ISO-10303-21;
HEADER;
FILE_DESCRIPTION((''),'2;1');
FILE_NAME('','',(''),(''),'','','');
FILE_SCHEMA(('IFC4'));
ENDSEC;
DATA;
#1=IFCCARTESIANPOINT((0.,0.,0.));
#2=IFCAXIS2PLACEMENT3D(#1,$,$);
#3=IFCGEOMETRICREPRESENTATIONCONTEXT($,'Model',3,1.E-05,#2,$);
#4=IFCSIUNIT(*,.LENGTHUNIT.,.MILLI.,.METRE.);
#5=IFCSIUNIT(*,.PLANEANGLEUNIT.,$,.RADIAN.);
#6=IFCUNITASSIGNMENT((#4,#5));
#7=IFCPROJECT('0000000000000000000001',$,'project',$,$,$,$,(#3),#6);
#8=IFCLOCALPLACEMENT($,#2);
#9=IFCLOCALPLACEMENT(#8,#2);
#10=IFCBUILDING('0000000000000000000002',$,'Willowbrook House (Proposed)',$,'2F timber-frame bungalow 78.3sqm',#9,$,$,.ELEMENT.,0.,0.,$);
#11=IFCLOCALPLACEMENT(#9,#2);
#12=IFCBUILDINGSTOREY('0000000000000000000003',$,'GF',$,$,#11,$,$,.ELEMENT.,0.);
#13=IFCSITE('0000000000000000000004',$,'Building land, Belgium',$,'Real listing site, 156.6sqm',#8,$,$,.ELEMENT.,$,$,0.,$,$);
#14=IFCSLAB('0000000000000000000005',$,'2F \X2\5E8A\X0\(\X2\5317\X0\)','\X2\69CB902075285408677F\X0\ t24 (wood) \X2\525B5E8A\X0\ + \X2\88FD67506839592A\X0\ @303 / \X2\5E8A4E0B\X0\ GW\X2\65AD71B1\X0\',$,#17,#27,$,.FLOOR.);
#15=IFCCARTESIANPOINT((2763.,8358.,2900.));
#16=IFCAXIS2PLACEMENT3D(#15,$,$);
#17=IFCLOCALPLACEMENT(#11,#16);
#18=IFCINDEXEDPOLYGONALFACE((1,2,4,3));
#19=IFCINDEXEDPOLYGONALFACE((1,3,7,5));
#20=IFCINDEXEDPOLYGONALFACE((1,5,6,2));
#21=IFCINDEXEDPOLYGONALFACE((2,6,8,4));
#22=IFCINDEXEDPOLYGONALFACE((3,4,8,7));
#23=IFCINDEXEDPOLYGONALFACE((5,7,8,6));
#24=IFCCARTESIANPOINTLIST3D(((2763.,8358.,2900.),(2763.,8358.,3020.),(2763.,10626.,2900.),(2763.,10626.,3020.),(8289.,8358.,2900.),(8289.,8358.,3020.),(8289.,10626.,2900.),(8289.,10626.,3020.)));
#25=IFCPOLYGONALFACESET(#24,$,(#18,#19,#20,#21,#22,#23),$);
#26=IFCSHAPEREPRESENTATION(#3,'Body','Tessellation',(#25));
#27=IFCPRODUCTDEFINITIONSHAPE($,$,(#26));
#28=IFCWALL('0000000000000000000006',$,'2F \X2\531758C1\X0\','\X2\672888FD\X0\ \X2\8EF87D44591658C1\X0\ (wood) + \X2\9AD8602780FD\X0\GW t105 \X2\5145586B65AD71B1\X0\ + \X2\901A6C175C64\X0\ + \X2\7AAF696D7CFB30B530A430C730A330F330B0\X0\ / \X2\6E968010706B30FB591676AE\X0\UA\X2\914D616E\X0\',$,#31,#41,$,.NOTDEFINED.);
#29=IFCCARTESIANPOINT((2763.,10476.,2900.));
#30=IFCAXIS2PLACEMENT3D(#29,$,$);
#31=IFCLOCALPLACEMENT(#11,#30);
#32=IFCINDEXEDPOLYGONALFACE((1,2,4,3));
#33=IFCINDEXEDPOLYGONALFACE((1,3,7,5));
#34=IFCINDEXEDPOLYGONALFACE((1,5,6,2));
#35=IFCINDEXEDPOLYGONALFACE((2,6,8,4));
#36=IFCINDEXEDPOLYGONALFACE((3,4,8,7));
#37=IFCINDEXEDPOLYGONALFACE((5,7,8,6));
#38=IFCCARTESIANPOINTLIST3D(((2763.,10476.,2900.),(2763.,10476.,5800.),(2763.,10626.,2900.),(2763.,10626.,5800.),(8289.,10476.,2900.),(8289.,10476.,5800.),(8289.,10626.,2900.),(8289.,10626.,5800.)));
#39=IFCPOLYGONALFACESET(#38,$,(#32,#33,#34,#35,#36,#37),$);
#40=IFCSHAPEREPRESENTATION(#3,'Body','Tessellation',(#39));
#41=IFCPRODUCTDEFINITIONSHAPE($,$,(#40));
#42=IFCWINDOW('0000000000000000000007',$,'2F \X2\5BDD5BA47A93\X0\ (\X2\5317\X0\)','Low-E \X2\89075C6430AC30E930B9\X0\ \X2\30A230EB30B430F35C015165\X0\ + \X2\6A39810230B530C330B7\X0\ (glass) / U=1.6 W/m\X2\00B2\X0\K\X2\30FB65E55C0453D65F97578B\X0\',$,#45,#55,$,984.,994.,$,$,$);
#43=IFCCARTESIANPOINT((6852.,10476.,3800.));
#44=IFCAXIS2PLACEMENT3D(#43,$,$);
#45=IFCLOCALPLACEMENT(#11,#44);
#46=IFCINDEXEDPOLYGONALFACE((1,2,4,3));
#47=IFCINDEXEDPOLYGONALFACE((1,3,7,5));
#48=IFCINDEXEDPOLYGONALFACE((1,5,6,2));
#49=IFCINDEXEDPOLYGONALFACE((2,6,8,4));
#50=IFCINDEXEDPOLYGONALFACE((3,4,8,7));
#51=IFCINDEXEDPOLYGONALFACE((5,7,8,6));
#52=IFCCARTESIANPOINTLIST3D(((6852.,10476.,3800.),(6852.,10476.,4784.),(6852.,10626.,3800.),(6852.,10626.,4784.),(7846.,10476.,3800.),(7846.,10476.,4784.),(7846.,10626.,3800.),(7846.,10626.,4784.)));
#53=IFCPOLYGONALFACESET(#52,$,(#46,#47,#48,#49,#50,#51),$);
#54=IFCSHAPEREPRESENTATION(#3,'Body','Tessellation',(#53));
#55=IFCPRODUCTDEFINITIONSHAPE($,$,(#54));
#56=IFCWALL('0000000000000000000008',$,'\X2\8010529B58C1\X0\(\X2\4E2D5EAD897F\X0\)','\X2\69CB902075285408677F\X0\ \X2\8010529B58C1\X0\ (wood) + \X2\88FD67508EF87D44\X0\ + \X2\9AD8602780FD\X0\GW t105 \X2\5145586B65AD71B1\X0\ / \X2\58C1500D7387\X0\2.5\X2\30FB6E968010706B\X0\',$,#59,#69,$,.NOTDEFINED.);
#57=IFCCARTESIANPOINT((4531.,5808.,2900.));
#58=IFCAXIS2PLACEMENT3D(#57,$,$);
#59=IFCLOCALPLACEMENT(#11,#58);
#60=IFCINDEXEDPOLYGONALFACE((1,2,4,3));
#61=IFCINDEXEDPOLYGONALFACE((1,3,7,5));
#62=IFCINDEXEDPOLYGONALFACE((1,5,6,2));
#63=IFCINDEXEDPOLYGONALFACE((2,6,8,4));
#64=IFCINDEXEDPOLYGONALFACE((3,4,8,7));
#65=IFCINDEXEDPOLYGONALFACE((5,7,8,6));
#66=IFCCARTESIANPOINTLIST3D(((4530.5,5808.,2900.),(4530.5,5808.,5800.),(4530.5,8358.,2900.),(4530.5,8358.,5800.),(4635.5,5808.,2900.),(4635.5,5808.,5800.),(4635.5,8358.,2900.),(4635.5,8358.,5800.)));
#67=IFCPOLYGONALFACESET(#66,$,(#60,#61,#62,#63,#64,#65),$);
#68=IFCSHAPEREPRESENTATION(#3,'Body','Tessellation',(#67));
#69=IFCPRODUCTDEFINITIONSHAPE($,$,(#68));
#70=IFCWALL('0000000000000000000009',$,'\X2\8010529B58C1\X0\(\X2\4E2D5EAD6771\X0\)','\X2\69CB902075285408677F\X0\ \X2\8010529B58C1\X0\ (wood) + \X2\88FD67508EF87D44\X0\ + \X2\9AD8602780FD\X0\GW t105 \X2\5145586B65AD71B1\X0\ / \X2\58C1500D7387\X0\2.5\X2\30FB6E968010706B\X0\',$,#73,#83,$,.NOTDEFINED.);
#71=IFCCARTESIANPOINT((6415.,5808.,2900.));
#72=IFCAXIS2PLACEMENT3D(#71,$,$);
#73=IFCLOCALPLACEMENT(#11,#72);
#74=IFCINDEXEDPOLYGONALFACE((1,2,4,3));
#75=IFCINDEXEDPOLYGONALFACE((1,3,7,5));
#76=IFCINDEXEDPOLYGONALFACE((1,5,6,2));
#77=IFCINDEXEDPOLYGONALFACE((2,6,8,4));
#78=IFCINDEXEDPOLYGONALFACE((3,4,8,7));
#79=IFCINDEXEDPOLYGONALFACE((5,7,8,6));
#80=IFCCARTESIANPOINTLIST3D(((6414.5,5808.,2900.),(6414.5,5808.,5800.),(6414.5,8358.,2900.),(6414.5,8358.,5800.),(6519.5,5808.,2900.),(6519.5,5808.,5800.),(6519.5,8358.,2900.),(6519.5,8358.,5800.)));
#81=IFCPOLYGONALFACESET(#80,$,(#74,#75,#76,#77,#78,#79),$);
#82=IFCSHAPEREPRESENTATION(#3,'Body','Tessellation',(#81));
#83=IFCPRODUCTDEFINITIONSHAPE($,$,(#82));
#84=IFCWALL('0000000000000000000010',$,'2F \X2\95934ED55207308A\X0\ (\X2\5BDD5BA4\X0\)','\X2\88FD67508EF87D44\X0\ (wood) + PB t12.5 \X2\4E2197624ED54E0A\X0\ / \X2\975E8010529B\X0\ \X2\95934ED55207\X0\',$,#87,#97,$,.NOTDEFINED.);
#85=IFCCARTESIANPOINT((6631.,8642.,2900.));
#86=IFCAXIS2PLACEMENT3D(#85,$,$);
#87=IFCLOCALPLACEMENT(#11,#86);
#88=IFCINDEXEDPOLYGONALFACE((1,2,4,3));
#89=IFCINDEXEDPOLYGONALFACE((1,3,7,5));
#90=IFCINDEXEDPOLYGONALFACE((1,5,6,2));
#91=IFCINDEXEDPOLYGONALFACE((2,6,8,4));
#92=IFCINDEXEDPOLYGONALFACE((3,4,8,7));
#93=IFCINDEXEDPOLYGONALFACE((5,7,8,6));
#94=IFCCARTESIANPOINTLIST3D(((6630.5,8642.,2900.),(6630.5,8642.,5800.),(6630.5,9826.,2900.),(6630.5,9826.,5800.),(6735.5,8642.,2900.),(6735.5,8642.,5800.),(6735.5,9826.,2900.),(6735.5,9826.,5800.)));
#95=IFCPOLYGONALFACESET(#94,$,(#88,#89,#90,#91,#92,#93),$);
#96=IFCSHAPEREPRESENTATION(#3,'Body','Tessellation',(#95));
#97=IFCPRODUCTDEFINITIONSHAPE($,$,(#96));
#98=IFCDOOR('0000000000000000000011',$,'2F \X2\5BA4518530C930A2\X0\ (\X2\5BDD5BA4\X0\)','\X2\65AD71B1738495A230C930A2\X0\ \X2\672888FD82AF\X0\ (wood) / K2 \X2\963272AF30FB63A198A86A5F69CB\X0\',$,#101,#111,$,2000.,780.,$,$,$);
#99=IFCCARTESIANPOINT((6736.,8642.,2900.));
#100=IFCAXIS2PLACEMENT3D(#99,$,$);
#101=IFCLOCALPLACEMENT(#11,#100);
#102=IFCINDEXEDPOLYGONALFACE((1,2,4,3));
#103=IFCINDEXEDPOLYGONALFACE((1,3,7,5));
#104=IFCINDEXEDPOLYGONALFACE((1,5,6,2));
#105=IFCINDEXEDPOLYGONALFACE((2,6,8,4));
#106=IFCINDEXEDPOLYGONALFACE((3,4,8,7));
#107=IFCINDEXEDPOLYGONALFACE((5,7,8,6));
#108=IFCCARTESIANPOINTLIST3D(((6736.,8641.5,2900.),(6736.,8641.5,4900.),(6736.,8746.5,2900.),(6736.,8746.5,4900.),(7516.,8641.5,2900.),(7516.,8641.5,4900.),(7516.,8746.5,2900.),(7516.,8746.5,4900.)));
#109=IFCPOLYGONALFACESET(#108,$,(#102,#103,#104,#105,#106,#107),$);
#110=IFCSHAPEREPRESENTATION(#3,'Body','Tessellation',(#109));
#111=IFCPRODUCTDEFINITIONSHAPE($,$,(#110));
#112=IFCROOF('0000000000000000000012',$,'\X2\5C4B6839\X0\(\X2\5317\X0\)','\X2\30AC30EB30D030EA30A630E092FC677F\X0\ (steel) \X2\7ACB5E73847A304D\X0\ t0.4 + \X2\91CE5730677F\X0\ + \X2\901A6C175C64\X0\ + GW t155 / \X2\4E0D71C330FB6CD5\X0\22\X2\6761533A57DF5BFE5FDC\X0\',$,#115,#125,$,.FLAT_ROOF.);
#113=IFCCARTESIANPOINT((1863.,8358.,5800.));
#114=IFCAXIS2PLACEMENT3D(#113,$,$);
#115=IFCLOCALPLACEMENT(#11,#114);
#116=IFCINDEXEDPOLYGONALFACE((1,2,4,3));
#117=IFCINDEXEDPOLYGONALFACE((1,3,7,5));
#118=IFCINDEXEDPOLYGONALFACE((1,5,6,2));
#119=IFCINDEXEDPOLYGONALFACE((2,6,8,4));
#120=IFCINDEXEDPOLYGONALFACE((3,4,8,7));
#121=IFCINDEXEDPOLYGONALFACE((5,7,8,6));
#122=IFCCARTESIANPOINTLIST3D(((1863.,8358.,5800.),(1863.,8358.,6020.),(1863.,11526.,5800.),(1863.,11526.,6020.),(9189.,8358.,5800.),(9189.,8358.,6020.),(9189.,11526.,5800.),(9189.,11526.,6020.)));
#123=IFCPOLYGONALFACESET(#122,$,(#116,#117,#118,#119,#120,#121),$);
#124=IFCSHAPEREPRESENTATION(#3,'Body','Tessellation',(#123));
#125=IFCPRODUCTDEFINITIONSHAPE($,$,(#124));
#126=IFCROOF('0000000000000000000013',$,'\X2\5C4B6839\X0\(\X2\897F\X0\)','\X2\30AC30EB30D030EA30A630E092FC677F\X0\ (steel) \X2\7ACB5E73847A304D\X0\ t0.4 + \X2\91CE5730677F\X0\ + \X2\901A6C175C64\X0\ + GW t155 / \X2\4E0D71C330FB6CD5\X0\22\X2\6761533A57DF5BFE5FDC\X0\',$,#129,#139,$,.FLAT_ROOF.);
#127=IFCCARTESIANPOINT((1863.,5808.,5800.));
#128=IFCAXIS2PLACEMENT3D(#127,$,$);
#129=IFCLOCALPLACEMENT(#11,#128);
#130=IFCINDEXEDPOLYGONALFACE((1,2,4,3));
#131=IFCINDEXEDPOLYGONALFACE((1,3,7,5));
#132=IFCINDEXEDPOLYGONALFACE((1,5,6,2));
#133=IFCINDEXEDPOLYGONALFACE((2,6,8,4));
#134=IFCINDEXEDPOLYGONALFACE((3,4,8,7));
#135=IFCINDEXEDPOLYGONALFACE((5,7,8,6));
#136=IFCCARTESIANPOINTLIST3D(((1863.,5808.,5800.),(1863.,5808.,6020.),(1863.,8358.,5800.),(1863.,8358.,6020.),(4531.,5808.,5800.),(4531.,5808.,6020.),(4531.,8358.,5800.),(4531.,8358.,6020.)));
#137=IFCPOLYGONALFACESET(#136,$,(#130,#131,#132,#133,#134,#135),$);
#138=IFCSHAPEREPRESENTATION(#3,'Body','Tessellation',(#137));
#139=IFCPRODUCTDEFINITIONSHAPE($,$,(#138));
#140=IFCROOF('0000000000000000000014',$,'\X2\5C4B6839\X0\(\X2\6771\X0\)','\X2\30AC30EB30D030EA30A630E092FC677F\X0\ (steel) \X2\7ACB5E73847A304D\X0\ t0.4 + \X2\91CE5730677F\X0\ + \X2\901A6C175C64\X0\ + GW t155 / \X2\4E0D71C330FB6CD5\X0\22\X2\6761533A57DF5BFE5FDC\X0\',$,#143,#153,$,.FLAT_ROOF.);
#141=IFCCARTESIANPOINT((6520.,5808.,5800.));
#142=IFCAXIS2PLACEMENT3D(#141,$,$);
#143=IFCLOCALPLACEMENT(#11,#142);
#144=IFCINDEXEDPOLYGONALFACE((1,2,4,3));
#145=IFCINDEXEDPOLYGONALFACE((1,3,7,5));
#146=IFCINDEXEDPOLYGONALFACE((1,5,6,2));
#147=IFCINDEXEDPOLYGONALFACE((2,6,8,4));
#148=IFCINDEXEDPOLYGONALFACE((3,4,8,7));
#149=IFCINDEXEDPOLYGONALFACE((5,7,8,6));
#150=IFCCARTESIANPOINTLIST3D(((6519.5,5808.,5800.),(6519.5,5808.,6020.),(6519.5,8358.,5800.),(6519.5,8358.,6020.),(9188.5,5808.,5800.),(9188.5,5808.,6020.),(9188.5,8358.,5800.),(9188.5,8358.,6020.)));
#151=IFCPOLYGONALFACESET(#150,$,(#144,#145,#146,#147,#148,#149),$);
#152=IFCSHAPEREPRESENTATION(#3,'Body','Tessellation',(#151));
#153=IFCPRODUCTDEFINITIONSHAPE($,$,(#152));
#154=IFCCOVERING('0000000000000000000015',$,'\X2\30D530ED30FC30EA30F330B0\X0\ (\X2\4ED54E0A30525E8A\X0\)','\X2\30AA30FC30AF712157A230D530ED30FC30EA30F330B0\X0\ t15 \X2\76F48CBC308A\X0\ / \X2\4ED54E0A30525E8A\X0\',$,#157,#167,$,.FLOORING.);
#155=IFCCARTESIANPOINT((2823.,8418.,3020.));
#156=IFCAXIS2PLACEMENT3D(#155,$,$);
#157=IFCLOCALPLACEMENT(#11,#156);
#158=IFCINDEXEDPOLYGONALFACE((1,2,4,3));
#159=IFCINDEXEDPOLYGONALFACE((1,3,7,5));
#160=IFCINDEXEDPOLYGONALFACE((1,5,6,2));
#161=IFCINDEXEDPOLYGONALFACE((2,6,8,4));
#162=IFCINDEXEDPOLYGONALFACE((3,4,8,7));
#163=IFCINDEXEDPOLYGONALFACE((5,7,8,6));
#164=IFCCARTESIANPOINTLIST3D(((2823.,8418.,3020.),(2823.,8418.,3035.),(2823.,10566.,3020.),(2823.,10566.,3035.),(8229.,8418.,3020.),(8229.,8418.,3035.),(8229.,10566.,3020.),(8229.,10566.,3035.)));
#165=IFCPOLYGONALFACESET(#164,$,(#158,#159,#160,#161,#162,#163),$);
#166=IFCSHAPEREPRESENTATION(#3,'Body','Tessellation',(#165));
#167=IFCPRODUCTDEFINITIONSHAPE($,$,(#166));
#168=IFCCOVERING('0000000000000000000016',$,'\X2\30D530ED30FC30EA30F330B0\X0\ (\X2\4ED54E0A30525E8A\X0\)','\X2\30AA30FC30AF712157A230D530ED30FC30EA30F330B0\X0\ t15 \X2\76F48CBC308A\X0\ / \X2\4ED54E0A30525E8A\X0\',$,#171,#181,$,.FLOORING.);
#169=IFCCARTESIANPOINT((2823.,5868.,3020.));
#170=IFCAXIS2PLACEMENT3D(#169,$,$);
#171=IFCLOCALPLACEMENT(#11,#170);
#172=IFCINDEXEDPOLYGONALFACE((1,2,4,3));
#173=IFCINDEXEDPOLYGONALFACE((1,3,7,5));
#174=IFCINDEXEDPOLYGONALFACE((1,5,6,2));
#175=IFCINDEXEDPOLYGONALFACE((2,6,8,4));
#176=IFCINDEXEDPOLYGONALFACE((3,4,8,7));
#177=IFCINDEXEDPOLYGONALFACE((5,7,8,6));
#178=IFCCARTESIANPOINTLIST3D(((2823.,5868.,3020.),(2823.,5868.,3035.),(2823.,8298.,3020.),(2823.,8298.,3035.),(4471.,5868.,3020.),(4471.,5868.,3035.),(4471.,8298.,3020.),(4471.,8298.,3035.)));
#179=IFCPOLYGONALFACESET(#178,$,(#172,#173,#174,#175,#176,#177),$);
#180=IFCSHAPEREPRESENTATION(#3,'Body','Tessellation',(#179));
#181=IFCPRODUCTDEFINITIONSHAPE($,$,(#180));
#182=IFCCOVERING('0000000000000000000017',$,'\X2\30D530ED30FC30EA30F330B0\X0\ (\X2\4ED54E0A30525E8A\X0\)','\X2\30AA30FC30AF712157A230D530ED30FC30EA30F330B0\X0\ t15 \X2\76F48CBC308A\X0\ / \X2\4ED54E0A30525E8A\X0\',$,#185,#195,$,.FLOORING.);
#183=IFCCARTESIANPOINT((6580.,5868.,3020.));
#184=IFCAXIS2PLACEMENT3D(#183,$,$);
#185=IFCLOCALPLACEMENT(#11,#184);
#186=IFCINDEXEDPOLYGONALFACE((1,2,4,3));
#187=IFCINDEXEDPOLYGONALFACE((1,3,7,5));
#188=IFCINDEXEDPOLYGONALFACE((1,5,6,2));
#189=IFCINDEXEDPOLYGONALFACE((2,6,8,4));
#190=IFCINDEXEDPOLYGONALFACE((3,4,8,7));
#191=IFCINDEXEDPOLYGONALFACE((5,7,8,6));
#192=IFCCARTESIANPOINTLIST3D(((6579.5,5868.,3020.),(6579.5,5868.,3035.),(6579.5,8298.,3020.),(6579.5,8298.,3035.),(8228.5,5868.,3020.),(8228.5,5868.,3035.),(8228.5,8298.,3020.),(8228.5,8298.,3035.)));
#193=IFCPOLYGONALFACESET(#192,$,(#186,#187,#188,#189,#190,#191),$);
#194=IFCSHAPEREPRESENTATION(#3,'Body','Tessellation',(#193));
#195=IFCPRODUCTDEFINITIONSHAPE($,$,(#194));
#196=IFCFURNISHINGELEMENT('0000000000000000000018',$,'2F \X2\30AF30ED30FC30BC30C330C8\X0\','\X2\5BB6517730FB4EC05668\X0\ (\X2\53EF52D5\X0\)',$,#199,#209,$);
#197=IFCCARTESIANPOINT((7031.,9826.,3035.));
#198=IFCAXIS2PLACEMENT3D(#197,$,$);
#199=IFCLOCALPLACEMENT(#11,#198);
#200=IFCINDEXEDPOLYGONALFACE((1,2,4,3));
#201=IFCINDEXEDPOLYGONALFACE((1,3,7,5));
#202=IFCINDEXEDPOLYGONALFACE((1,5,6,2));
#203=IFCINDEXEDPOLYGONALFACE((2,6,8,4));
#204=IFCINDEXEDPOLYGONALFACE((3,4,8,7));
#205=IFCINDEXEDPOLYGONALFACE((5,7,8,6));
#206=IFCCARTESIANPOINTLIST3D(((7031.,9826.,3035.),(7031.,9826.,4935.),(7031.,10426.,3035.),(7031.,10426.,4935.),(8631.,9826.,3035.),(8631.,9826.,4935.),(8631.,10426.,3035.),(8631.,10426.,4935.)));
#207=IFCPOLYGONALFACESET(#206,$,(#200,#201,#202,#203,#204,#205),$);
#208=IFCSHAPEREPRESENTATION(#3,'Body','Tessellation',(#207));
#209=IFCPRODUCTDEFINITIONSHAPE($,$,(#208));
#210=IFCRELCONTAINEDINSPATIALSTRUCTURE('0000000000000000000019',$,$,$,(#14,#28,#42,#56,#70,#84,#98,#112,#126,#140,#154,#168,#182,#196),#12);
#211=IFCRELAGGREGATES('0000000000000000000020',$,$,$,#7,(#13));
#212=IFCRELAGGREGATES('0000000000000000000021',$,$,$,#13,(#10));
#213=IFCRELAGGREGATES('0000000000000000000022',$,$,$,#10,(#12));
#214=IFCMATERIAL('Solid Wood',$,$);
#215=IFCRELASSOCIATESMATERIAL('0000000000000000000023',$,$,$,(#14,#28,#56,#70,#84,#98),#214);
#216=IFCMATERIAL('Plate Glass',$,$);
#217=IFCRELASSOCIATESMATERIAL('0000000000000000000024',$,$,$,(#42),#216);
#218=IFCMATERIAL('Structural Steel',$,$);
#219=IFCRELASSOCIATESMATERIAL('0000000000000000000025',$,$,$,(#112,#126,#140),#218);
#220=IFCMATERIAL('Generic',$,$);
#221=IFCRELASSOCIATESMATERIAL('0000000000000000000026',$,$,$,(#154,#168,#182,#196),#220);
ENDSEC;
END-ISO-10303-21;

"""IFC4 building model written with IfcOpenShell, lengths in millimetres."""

from ifc_helpers import new_model, si_unit, frame, frame_2d, origin, place, context, project, spatial, rectangle, extrude, material, element, fill, save


model = new_model("IFC4")

# Units and contexts
model_context = context("Model", 3, precision=1e-05, world=origin())
ifc_project = project(units=[si_unit("LENGTHUNIT", "METRE", prefix="MILLI"), si_unit("PLANEANGLEUNIT", "RADIAN")], contexts=[model_context])

# Site, building, storey
site_placement = place(None, origin())
site = spatial("IfcSite", under=ifc_project, at=site_placement, Name="Building land, Belgium", ObjectType="Real listing site, 156.6sqm", CompositionType="ELEMENT", RefElevation=0.0)
building_placement = place(site_placement, origin())
building = spatial("IfcBuilding", under=site, at=building_placement, Name="Willowbrook House (Proposed)", ObjectType="2F timber-frame bungalow 78.3sqm", CompositionType="ELEMENT", ElevationOfRefHeight=0.0, ElevationOfTerrain=0.0)
storey_placement = place(building_placement, origin())
storey = spatial("IfcBuildingStorey", under=building, at=storey_placement, Name="GF", CompositionType="ELEMENT", Elevation=0.0)

# Slab
ifc_material_1 = material(Name="Solid Wood")
slab_placement = place(storey_placement, frame((2763.0, 8358.0, 2900.0)))
element("IfcSlab", 1, at=slab_placement, inside=storey, material=ifc_material_1, Name="2F 床(北)", Description="構造用合板 t24 (wood) 剛床 + 製材根太 @303 / 床下 GW断熱", PredefinedType="FLOOR", context=model_context, shape_type="SweptSolid", body=[
    extrude(rectangle(XDim=5526.0, YDim=2268.0, at=frame_2d((2763.0, 1134.0))), frame((2763.0, 8358.0, 2900.0)), (0.0, 0.0, 1.0), 120.0),
])

# Wall, opening, window
wall_1_placement = place(storey_placement, frame((2763.0, 10476.0, 2900.0)))
wall_1 = element("IfcWall", 2, at=wall_1_placement, inside=storey, material=ifc_material_1, Name="2F 北壁", Description="木製 軸組外壁 (wood) + 高性能GW t105 充填断熱 + 通気層 + 窯業系サイディング / 準耐火・外皮UA配慮", PredefinedType="NOTDEFINED", context=model_context, shape_type="SweptSolid", body=[
    extrude(rectangle(XDim=5526.0, YDim=150.0, at=frame_2d((2763.0, 75.0))), frame((2763.0, 10476.0, 2900.0)), (0.0, 0.0, 1.0), 2900.0),
])
opening_1_placement = place(storey_placement, frame((6852.0, 10476.0, 3800.0)))
opening_1 = element("IfcOpeningElement", 3, at=opening_1_placement, cuts=wall_1, PredefinedType="NOTDEFINED", context=model_context, shape_type="SweptSolid", body=[
    extrude(rectangle(XDim=994.0, YDim=150.0, at=frame_2d((497.0, 75.0))), frame((6852.0, 10476.0, 3800.0)), (0.0, 0.0, 1.0), 984.0),
])
ifc_material_2 = material(Name="Plate Glass")
window_1_placement = place(storey_placement, frame((6852.0, 10476.0, 3800.0)))
window_1 = element("IfcWindow", 4, at=window_1_placement, inside=storey, material=ifc_material_2, Name="2F 寝室窓 (北)", Description="Low-E 複層ガラス アルゴン封入 + 樹脂サッシ (glass) / U=1.6 W/m²K・日射取得型", OverallHeight=984.0, OverallWidth=994.0, context=model_context, shape_type="SweptSolid", body=[
    extrude(rectangle(XDim=994.0, YDim=150.0, at=frame_2d((497.0, 75.0))), frame((6852.0, 10476.0, 3800.0)), (0.0, 0.0, 1.0), 984.0),
])
fill(opening_1, window_1)

# Walls
wall_2_placement = place(storey_placement, frame((4531.0, 5808.0, 2900.0)))
element("IfcWall", 5, at=wall_2_placement, inside=storey, material=ifc_material_1, Name="耐力壁(中庭西)", Description="構造用合板 耐力壁 (wood) + 製材軸組 + 高性能GW t105 充填断熱 / 壁倍率2.5・準耐火", PredefinedType="NOTDEFINED", context=model_context, shape_type="SweptSolid", body=[
    extrude(rectangle(XDim=105.0, YDim=2550.0, at=frame_2d((52.0, 1275.0))), frame((4531.0, 5808.0, 2900.0)), (0.0, 0.0, 1.0), 2900.0),
])
wall_3_placement = place(storey_placement, frame((6415.0, 5808.0, 2900.0)))
element("IfcWall", 6, at=wall_3_placement, inside=storey, material=ifc_material_1, Name="耐力壁(中庭東)", Description="構造用合板 耐力壁 (wood) + 製材軸組 + 高性能GW t105 充填断熱 / 壁倍率2.5・準耐火", PredefinedType="NOTDEFINED", context=model_context, shape_type="SweptSolid", body=[
    extrude(rectangle(XDim=105.0, YDim=2550.0, at=frame_2d((52.0, 1275.0))), frame((6415.0, 5808.0, 2900.0)), (0.0, 0.0, 1.0), 2900.0),
])
wall_4_placement = place(storey_placement, frame((6631.0, 8642.0, 2900.0)))
element("IfcWall", 7, at=wall_4_placement, inside=storey, material=ifc_material_1, Name="2F 間仕切り (寝室)", Description="製材軸組 (wood) + PB t12.5 両面仕上 / 非耐力 間仕切", PredefinedType="NOTDEFINED", context=model_context, shape_type="SweptSolid", body=[
    extrude(rectangle(XDim=105.0, YDim=1184.0, at=frame_2d((52.0, 592.0))), frame((6631.0, 8642.0, 2900.0)), (0.0, 0.0, 1.0), 2900.0),
])

# Door
door_placement = place(storey_placement, frame((6736.0, 8642.0, 2900.0)))
element("IfcDoor", 8, at=door_placement, inside=storey, material=ifc_material_1, Name="2F 室内ドア (寝室)", Description="断熱玄関ドア 木製芯 (wood) / K2 防犯・採風機構", OverallHeight=2000.0, OverallWidth=780.0, context=model_context, shape_type="SweptSolid", body=[
    extrude(rectangle(XDim=780.0, YDim=105.0, at=frame_2d((390.0, 52.0))), frame((6736.0, 8642.0, 2900.0)), (0.0, 0.0, 1.0), 2000.0),
])

# Roofs
ifc_material_3 = material(Name="Structural Steel")
for number, where, name in (
    (9, (1863.0, 8358.0, 5800.0), "屋根(北)"),
):
    element("IfcRoof", number, at=place(storey_placement, frame(where)), inside=storey, material=ifc_material_3, Name=name, Description="ガルバリウム鋼板 (steel) 立平葺き t0.4 + 野地板 + 通気層 + GW t155 / 不燃・法22条区域対応", PredefinedType="FLAT_ROOF", context=model_context, shape_type="SweptSolid", body=[
        extrude(rectangle(XDim=7326.0, YDim=3168.0, at=frame_2d((3663.0, 1584.0))), frame((1863.0, 8358.0, 5800.0)), (0.0, 0.0, 1.0), 220.0),
    ])
roof_1_placement = place(storey_placement, frame((1863.0, 5808.0, 5800.0)))
element("IfcRoof", 10, at=roof_1_placement, inside=storey, material=ifc_material_3, Name="屋根(西)", Description="ガルバリウム鋼板 (steel) 立平葺き t0.4 + 野地板 + 通気層 + GW t155 / 不燃・法22条区域対応", PredefinedType="FLAT_ROOF", context=model_context, shape_type="SweptSolid", body=[
    extrude(rectangle(XDim=2668.0, YDim=2550.0, at=frame_2d((1334.0, 1275.0))), frame((1863.0, 5808.0, 5800.0)), (0.0, 0.0, 1.0), 220.0),
])
roof_2_placement = place(storey_placement, frame((6520.0, 5808.0, 5800.0)))
element("IfcRoof", 11, at=roof_2_placement, inside=storey, material=ifc_material_3, Name="屋根(東)", Description="ガルバリウム鋼板 (steel) 立平葺き t0.4 + 野地板 + 通気層 + GW t155 / 不燃・法22条区域対応", PredefinedType="FLAT_ROOF", context=model_context, shape_type="SweptSolid", body=[
    extrude(rectangle(XDim=2669.0, YDim=2550.0, at=frame_2d((1334.0, 1275.0))), frame((6520.0, 5808.0, 5800.0)), (0.0, 0.0, 1.0), 220.0),
])

# Coverings
ifc_material_4 = material(Name="Generic")
covering_1_placement = place(storey_placement, frame((2823.0, 8418.0, 3020.0)))
element("IfcCovering", 12, at=covering_1_placement, inside=storey, material=ifc_material_4, Name="フローリング (仕上げ床)", Description="オーク無垢フローリング t15 直貼り / 仕上げ床", PredefinedType="FLOORING", context=model_context, shape_type="SweptSolid", body=[
    extrude(rectangle(XDim=5406.0, YDim=2148.0, at=frame_2d((2703.0, 1074.0))), frame((2823.0, 8418.0, 3020.0)), (0.0, 0.0, 1.0), 15.0),
])
covering_2_placement = place(storey_placement, frame((2823.0, 5868.0, 3020.0)))
element("IfcCovering", 13, at=covering_2_placement, inside=storey, material=ifc_material_4, Name="フローリング (仕上げ床)", Description="オーク無垢フローリング t15 直貼り / 仕上げ床", PredefinedType="FLOORING", context=model_context, shape_type="SweptSolid", body=[
    extrude(rectangle(XDim=1648.0, YDim=2430.0, at=frame_2d((824.0, 1215.0))), frame((2823.0, 5868.0, 3020.0)), (0.0, 0.0, 1.0), 15.0),
])
covering_3_placement = place(storey_placement, frame((6580.0, 5868.0, 3020.0)))
element("IfcCovering", 14, at=covering_3_placement, inside=storey, material=ifc_material_4, Name="フローリング (仕上げ床)", Description="オーク無垢フローリング t15 直貼り / 仕上げ床", PredefinedType="FLOORING", context=model_context, shape_type="SweptSolid", body=[
    extrude(rectangle(XDim=1649.0, YDim=2430.0, at=frame_2d((824.0, 1215.0))), frame((6580.0, 5868.0, 3020.0)), (0.0, 0.0, 1.0), 15.0),
])

# Furnishing element
furnishing_1_placement = place(storey_placement, frame((7031.0, 9826.0, 3035.0)))
element("IfcFurnishingElement", 15, at=furnishing_1_placement, inside=storey, material=ifc_material_4, Name="2F クローゼット", Description="家具・什器 (可動)", context=model_context, shape_type="SweptSolid", body=[
    extrude(rectangle(XDim=1600.0, YDim=600.0, at=frame_2d((800.0, 300.0))), frame((7031.0, 9826.0, 3035.0)), (0.0, 0.0, 1.0), 1900.0),
])

save(model, "model.ifc")
